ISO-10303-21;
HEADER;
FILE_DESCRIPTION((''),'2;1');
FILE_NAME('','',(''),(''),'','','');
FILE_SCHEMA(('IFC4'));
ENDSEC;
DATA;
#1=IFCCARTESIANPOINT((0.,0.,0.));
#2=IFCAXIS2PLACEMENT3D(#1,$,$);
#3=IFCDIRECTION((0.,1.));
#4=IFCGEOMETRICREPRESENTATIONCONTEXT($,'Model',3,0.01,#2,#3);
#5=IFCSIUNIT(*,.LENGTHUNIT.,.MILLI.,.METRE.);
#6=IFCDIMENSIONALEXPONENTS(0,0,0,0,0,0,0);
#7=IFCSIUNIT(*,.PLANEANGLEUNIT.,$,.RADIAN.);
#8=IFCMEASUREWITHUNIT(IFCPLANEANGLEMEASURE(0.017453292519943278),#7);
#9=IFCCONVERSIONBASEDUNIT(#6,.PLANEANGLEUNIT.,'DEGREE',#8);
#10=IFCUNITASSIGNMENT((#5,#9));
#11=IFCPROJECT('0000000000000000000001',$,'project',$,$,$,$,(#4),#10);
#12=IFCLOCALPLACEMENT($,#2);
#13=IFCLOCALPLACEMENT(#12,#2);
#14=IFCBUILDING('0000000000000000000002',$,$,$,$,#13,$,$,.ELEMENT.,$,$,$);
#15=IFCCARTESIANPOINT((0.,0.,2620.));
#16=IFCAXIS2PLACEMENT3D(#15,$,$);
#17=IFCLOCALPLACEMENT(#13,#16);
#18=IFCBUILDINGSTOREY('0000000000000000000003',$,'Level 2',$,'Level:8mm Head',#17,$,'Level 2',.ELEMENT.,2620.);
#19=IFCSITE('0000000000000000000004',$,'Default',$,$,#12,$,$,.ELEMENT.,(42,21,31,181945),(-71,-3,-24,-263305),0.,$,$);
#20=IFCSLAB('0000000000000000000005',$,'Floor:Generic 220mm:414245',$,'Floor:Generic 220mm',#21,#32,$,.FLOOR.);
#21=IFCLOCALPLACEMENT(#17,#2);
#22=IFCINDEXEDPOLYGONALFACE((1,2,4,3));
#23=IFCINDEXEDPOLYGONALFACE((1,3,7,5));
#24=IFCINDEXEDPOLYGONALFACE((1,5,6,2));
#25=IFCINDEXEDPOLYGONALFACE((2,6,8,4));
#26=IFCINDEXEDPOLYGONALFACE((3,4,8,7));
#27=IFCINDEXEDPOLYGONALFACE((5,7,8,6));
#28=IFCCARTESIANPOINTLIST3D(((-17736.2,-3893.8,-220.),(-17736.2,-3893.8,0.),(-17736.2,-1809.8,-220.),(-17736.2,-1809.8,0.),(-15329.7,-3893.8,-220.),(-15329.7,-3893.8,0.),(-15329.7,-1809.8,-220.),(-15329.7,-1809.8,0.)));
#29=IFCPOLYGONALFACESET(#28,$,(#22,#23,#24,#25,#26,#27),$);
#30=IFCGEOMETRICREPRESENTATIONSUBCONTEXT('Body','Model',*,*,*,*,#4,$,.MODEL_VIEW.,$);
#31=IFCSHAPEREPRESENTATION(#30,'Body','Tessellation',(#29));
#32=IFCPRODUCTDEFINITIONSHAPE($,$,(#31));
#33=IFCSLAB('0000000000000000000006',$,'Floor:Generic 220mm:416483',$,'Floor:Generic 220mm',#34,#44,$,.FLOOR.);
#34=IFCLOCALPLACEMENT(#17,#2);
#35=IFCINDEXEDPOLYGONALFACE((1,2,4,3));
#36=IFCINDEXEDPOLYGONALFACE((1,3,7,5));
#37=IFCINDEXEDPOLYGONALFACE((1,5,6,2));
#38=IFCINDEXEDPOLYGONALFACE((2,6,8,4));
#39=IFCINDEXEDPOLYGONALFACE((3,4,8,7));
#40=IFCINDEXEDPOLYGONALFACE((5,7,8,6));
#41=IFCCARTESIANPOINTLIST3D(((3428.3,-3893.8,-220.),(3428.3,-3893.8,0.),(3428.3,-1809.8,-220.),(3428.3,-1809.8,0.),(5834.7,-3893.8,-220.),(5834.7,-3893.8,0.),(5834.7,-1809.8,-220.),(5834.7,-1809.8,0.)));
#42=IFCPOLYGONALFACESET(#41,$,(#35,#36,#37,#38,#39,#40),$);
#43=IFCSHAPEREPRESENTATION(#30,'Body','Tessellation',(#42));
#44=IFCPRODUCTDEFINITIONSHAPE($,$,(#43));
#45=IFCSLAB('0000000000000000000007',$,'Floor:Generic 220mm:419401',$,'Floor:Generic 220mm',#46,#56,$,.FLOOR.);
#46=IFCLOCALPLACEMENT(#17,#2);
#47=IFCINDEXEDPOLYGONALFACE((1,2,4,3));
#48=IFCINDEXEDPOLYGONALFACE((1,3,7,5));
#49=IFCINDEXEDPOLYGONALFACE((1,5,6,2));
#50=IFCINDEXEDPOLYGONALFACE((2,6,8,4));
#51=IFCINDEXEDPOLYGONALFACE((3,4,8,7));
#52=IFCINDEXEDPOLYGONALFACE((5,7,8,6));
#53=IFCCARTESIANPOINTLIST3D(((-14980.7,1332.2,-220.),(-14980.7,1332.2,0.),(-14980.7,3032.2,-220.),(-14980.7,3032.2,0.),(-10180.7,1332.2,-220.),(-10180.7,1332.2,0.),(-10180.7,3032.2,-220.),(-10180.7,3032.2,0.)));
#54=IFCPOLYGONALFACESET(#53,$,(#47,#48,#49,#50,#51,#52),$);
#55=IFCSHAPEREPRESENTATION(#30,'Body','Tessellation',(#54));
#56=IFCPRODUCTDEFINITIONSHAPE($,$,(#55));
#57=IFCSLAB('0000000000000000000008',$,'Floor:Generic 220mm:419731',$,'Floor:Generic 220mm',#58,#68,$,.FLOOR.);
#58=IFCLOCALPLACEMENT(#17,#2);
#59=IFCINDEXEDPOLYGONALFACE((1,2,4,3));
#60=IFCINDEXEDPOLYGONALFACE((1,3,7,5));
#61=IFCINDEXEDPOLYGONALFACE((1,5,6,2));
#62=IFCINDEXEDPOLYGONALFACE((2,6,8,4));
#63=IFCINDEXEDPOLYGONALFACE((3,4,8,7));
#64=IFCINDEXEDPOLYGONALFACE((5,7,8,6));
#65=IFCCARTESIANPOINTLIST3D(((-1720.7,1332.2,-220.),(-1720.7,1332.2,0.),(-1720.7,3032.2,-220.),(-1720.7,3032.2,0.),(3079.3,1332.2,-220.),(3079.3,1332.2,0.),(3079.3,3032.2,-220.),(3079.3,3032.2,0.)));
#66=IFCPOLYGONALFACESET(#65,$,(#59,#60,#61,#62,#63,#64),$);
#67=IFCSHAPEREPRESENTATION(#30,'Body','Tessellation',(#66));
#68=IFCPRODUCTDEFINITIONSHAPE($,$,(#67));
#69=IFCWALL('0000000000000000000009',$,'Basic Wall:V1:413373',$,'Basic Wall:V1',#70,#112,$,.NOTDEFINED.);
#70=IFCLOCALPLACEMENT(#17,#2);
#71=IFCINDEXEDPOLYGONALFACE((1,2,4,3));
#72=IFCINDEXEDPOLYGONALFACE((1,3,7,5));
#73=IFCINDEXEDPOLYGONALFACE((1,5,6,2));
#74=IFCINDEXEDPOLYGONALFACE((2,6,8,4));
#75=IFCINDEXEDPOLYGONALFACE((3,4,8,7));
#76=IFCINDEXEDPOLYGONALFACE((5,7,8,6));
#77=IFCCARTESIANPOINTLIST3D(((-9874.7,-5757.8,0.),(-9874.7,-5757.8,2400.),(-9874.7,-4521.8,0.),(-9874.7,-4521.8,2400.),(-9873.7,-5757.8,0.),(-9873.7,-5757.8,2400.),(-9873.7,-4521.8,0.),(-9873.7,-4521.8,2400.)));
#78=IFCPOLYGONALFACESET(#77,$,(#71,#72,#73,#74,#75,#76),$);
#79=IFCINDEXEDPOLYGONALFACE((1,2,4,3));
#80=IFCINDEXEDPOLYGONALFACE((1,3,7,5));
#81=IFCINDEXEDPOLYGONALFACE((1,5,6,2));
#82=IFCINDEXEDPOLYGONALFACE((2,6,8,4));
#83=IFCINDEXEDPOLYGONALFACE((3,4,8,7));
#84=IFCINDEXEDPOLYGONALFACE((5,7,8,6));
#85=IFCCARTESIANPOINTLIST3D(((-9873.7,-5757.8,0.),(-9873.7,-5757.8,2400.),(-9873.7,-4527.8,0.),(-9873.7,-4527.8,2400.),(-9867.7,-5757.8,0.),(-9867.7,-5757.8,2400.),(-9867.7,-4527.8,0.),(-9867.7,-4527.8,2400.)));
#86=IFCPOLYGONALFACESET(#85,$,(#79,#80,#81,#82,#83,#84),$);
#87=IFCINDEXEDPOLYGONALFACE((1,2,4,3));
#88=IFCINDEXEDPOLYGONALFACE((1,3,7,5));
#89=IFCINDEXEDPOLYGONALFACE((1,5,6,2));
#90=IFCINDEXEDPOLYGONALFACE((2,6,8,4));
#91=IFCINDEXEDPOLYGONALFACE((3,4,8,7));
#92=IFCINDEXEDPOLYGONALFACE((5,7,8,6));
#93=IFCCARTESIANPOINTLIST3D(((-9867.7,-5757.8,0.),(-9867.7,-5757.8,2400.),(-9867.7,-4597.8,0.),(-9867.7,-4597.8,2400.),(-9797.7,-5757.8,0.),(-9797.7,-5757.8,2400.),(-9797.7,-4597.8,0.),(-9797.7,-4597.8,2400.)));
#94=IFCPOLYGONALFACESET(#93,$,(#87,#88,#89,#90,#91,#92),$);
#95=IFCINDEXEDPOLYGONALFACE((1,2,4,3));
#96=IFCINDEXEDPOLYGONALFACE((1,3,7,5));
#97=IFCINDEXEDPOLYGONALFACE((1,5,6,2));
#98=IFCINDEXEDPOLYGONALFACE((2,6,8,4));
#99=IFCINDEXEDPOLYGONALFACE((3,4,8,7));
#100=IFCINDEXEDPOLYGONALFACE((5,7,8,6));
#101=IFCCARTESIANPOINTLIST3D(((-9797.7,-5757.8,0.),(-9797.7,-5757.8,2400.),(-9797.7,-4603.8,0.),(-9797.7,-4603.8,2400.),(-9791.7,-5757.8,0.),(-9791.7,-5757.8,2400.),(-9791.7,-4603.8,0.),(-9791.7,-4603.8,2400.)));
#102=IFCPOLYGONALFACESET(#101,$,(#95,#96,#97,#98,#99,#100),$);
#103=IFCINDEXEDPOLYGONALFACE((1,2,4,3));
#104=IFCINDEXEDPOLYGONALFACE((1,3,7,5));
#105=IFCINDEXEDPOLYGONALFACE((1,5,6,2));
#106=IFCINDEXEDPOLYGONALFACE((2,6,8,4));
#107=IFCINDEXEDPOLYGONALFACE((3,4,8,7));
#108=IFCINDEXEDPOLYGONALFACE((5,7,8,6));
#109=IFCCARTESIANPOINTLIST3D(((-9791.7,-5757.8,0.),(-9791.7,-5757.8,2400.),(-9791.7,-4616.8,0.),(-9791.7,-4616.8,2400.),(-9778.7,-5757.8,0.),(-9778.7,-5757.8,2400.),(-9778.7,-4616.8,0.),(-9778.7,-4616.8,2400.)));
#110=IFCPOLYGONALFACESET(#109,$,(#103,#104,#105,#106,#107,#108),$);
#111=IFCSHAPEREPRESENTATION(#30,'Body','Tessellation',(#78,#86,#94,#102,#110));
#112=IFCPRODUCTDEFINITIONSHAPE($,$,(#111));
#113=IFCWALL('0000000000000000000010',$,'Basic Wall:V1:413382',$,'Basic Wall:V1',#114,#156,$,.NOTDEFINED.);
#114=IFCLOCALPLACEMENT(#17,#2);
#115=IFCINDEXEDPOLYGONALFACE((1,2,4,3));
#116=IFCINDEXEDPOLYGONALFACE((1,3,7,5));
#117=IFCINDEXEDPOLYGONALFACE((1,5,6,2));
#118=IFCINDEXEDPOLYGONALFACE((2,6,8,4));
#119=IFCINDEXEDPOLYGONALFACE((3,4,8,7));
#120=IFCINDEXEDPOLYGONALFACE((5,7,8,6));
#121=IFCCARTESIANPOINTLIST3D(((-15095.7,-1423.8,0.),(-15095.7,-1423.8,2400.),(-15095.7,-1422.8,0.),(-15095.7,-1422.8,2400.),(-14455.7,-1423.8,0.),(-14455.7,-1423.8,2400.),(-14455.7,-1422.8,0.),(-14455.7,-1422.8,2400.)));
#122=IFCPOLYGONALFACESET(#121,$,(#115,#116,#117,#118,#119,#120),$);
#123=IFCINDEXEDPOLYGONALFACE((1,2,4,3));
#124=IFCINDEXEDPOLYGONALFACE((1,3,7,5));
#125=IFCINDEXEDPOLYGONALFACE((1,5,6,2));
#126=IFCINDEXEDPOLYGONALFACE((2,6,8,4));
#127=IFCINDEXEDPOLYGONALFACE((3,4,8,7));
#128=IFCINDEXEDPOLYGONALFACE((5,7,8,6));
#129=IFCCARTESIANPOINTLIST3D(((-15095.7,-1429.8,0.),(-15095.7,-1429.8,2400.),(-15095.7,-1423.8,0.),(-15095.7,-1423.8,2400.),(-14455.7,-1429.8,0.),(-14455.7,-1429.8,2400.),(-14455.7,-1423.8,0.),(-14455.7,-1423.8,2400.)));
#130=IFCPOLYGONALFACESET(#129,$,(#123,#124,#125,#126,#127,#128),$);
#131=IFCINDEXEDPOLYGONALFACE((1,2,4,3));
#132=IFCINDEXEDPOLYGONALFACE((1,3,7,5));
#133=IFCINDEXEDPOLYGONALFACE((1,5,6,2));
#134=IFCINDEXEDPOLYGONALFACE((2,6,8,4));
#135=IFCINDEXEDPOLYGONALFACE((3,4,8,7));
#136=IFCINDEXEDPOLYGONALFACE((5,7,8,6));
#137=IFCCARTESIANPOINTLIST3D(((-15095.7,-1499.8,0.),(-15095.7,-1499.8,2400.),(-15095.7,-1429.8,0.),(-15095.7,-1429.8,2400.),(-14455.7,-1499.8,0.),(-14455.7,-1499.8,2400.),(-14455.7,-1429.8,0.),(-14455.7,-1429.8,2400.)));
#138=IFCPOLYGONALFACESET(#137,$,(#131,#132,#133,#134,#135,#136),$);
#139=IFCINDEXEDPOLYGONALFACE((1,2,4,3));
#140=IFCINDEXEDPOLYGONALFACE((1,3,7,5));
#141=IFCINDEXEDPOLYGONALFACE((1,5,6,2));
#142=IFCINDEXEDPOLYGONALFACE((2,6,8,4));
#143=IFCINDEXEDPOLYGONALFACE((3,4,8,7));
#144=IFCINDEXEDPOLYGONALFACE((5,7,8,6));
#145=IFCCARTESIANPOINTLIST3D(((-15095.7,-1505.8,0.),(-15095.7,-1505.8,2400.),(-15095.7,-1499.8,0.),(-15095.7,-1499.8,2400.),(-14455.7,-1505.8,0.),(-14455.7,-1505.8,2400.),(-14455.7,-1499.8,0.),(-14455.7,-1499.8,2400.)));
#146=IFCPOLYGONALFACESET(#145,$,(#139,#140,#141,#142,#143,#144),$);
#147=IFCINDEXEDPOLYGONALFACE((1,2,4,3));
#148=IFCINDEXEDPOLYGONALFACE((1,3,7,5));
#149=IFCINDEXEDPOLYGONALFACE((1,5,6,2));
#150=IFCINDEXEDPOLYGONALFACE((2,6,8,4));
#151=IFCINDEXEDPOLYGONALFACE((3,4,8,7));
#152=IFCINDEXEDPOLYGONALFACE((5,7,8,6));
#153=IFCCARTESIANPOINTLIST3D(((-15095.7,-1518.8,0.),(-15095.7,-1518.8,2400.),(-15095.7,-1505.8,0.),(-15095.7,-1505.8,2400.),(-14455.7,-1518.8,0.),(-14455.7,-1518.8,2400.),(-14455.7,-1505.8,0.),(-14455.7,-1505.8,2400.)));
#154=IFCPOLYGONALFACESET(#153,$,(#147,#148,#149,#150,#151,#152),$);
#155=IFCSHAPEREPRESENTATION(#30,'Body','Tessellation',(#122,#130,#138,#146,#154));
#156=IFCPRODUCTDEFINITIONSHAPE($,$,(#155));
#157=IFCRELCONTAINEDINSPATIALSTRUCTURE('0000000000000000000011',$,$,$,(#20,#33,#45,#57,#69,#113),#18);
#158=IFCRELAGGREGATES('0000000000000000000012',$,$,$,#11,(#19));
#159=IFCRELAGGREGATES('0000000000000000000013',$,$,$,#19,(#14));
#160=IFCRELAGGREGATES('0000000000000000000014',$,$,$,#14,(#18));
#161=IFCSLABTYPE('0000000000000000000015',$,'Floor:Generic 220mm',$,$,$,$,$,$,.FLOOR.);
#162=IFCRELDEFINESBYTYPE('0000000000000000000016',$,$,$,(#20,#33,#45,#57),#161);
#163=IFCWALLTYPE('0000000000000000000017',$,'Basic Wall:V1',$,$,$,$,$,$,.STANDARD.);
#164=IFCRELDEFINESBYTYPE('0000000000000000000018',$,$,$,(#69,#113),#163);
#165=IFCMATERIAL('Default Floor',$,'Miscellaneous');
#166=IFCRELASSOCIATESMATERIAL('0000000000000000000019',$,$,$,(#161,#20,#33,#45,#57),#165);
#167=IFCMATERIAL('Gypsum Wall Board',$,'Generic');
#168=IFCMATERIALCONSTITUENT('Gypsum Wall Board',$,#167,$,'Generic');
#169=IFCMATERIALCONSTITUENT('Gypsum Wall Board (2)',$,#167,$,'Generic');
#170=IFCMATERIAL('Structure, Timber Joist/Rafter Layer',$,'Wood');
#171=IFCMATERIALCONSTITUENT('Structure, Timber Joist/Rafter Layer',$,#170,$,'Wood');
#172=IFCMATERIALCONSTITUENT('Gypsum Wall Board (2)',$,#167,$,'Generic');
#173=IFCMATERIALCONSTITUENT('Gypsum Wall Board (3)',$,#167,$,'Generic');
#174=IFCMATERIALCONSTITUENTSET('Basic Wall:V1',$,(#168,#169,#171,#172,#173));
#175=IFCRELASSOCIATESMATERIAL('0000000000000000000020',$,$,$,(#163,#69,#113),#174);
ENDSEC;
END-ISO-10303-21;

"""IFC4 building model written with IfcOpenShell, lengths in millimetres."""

from ifc_helpers import new_model, entity, si_unit, converted_unit, direction, frame, origin, place, context, subcontext, project, spatial, indexed_curve, outline, extrude, material, constituent, constituent_set, type_object, element, save


model = new_model("IFC4")

# Units and contexts
model_context = context("Model", 3, precision=0.01, world=origin(), true_north=direction((0.0, 1.0)))
body_context = subcontext(model_context, "Body", "Model", "MODEL_VIEW")
ifc_project = project(units=[si_unit("LENGTHUNIT", "METRE", prefix="MILLI"), converted_unit("PLANEANGLEUNIT", "DEGREE", entity("IfcPlaneAngleMeasure", 0.017453292519943278), si_unit("PLANEANGLEUNIT", "RADIAN"), dimensions=[0, 0, 0, 0, 0, 0, 0])], contexts=[model_context])

# Site, building, storey
site_placement = place(None, origin())
site = spatial("IfcSite", under=ifc_project, at=site_placement, Name="Default", CompositionType="ELEMENT", RefLatitude=(42, 21, 31, 181945), RefLongitude=(-71, -3, -24, -263305), RefElevation=0.0)
building_placement = place(site_placement, origin())
building = spatial("IfcBuilding", under=site, at=building_placement, CompositionType="ELEMENT")
storey_placement = place(building_placement, frame((0.0, 0.0, 2620.0)))
storey = spatial("IfcBuildingStorey", under=building, at=storey_placement, Name="Level 2", ObjectType="Level:8mm Head", LongName="Level 2", CompositionType="ELEMENT", Elevation=2620.0)

# Slabs
ifc_material_1 = material(Name="Default Floor", Category="Miscellaneous")
slab_type = type_object("IfcSlabType", Name="Floor:Generic 220mm", PredefinedType="FLOOR", material=ifc_material_1)
slab_1_placement = place(storey_placement, origin())
element("IfcSlab", 1, at=slab_1_placement, inside=storey, type_object=slab_type, material=ifc_material_1, Name="Floor:Generic 220mm:414245", ObjectType="Floor:Generic 220mm", PredefinedType="FLOOR", context=body_context, shape_type="SweptSolid", body=[
    extrude(outline(indexed_curve([(-1042.0, -1203.2), (1042.0, -1203.2), (1042.0, 1203.2), (-1042.0, 1203.2), (-1042.0, -1203.2)], self_intersect=False)), frame((-16533.0, -2851.8, 0.0), z_axis=(0.0, 0.0, -1.0), x_axis=(0.0, 1.0, 0.0)), (0.0, 0.0, 1.0), 220.0),
])
slab_2_placement = place(storey_placement, origin())
element("IfcSlab", 2, at=slab_2_placement, inside=storey, type_object=slab_type, material=ifc_material_1, Name="Floor:Generic 220mm:416483", ObjectType="Floor:Generic 220mm", PredefinedType="FLOOR", context=body_context, shape_type="SweptSolid", body=[
    extrude(outline(indexed_curve([(-1042.0, -1203.2), (1042.0, -1203.2), (1042.0, 1203.2), (-1042.0, 1203.2), (-1042.0, -1203.2)], self_intersect=False)), frame((4631.5, -2851.8, 0.0), z_axis=(0.0, 0.0, -1.0), x_axis=(0.0, 1.0, 0.0)), (0.0, 0.0, 1.0), 220.0),
])
slab_3_placement = place(storey_placement, origin())
element("IfcSlab", 3, at=slab_3_placement, inside=storey, type_object=slab_type, material=ifc_material_1, Name="Floor:Generic 220mm:419401", ObjectType="Floor:Generic 220mm", PredefinedType="FLOOR", context=body_context, shape_type="SweptSolid", body=[
    extrude(outline(indexed_curve([(-850.0, -2400.0), (850.0, -2400.0), (850.0, 2400.0), (-850.0, 2400.0), (-850.0, -2400.0)], self_intersect=False)), frame((-12580.7, 2182.2, 0.0), z_axis=(0.0, 0.0, -1.0), x_axis=(0.0, 1.0, 0.0)), (0.0, 0.0, 1.0), 220.0),
])
slab_4_placement = place(storey_placement, origin())
element("IfcSlab", 4, at=slab_4_placement, inside=storey, type_object=slab_type, material=ifc_material_1, Name="Floor:Generic 220mm:419731", ObjectType="Floor:Generic 220mm", PredefinedType="FLOOR", context=body_context, shape_type="SweptSolid", body=[
    extrude(outline(indexed_curve([(-850.0, -2400.0), (850.0, -2400.0), (850.0, 2400.0), (-850.0, 2400.0), (-850.0, -2400.0)], self_intersect=False)), frame((679.3, 2182.2, 0.0), z_axis=(0.0, 0.0, -1.0), x_axis=(0.0, 1.0, 0.0)), (0.0, 0.0, 1.0), 220.0),
])

# Walls
ifc_material_2 = material(Name="Gypsum Wall Board", Category="Generic")
ifc_constituent_1 = constituent(ifc_material_2, Name="Gypsum Wall Board", Category="Generic")
ifc_constituent_2 = constituent(ifc_material_2, Name="Gypsum Wall Board (2)", Category="Generic")
ifc_material_3 = material(Name="Structure, Timber Joist/Rafter Layer", Category="Wood")
ifc_constituent_3 = constituent(ifc_material_3, Name="Structure, Timber Joist/Rafter Layer", Category="Wood")
ifc_constituent_4 = constituent(ifc_material_2, Name="Gypsum Wall Board (2)", Category="Generic")
ifc_constituent_5 = constituent(ifc_material_2, Name="Gypsum Wall Board (3)", Category="Generic")
ifc_constituent_set_1 = constituent_set(constituents=[ifc_constituent_1, ifc_constituent_2, ifc_constituent_3, ifc_constituent_4, ifc_constituent_5], Name="Basic Wall:V1")
wall_type_1 = type_object("IfcWallType", Name="Basic Wall:V1", PredefinedType="STANDARD", material=ifc_constituent_set_1)
wall_1_placement = place(storey_placement, frame((-9826.7, -4616.8, 0.0), z_axis=(0.0, 0.0, 1.0), x_axis=(0.0, -1.0, 0.0)))
element("IfcWall", 5, at=wall_1_placement, inside=storey, type_object=wall_type_1, material=ifc_constituent_set_1, Name="Basic Wall:V1:413373", ObjectType="Basic Wall:V1", PredefinedType="NOTDEFINED", context=body_context, shape_type="SweptSolid", body=[
    extrude(outline(indexed_curve([(-0.5, -618.0), (0.5, -618.0), (0.5, 618.0), (-0.5, 618.0), (-0.5, -618.0)], self_intersect=False)), frame((523.0, -47.5, 0.0), z_axis=(0.0, 0.0, 1.0), x_axis=(0.0, 1.0, 0.0)), (0.0, 0.0, 1.0), 2400.0),
    extrude(outline(indexed_curve([(-615.0, -3.0), (615.0, -3.0), (615.0, 3.0), (-615.0, 3.0), (-615.0, -3.0)], self_intersect=False)), frame((526.0, -44.0, 0.0)), (0.0, 0.0, 1.0), 2400.0),
    extrude(outline(indexed_curve([(-580.0, -35.0), (580.0, -35.0), (580.0, 35.0), (-580.0, 35.0), (-580.0, -35.0)], self_intersect=False)), frame((561.0, -6.0, 0.0)), (0.0, 0.0, 1.0), 2400.0),
    extrude(outline(indexed_curve([(-577.0, -3.0), (577.0, -3.0), (577.0, 3.0), (-577.0, 3.0), (-577.0, -3.0)], self_intersect=False)), frame((564.0, 32.0, 0.0)), (0.0, 0.0, 1.0), 2400.0),
    extrude(outline(indexed_curve([(-6.5, -570.5), (6.5, -570.5), (6.5, 570.5), (-6.5, 570.5), (-6.5, -570.5)], self_intersect=False)), frame((570.5, 41.5, 0.0), z_axis=(0.0, 0.0, 1.0), x_axis=(0.0, -1.0, 0.0)), (0.0, 0.0, 1.0), 2400.0),
])
wall_2_placement = place(storey_placement, frame((-14455.7, -1470.8, 0.0), z_axis=(0.0, 0.0, 1.0), x_axis=(-1.0, 0.0, 0.0)))
element("IfcWall", 6, at=wall_2_placement, inside=storey, type_object=wall_type_1, material=ifc_constituent_set_1, Name="Basic Wall:V1:413382", ObjectType="Basic Wall:V1", PredefinedType="NOTDEFINED", context=body_context, shape_type="SweptSolid", body=[
    extrude(outline(indexed_curve([(-0.5, -320.0), (0.5, -320.0), (0.5, 320.0), (-0.5, 320.0), (-0.5, -320.0)], self_intersect=False)), frame((320.0, -47.5, 0.0), z_axis=(0.0, 0.0, 1.0), x_axis=(0.0, 1.0, 0.0)), (0.0, 0.0, 1.0), 2400.0),
    extrude(outline(indexed_curve([(-320.0, -3.0), (320.0, -3.0), (320.0, 3.0), (-320.0, 3.0), (-320.0, -3.0)], self_intersect=False)), frame((320.0, -44.0, 0.0)), (0.0, 0.0, 1.0), 2400.0),
    extrude(outline(indexed_curve([(-320.0, -35.0), (320.0, -35.0), (320.0, 35.0), (-320.0, 35.0), (-320.0, -35.0)], self_intersect=False)), frame((320.0, -6.0, 0.0)), (0.0, 0.0, 1.0), 2400.0),
    extrude(outline(indexed_curve([(-320.0, -3.0), (320.0, -3.0), (320.0, 3.0), (-320.0, 3.0), (-320.0, -3.0)], self_intersect=False)), frame((320.0, 32.0, 0.0)), (0.0, 0.0, 1.0), 2400.0),
    extrude(outline(indexed_curve([(-6.5, -320.0), (6.5, -320.0), (6.5, 320.0), (-6.5, 320.0), (-6.5, -320.0)], self_intersect=False)), frame((320.0, 41.5, 0.0), z_axis=(0.0, 0.0, 1.0), x_axis=(0.0, -1.0, 0.0)), (0.0, 0.0, 1.0), 2400.0),
])

save(model, "model.ifc")
